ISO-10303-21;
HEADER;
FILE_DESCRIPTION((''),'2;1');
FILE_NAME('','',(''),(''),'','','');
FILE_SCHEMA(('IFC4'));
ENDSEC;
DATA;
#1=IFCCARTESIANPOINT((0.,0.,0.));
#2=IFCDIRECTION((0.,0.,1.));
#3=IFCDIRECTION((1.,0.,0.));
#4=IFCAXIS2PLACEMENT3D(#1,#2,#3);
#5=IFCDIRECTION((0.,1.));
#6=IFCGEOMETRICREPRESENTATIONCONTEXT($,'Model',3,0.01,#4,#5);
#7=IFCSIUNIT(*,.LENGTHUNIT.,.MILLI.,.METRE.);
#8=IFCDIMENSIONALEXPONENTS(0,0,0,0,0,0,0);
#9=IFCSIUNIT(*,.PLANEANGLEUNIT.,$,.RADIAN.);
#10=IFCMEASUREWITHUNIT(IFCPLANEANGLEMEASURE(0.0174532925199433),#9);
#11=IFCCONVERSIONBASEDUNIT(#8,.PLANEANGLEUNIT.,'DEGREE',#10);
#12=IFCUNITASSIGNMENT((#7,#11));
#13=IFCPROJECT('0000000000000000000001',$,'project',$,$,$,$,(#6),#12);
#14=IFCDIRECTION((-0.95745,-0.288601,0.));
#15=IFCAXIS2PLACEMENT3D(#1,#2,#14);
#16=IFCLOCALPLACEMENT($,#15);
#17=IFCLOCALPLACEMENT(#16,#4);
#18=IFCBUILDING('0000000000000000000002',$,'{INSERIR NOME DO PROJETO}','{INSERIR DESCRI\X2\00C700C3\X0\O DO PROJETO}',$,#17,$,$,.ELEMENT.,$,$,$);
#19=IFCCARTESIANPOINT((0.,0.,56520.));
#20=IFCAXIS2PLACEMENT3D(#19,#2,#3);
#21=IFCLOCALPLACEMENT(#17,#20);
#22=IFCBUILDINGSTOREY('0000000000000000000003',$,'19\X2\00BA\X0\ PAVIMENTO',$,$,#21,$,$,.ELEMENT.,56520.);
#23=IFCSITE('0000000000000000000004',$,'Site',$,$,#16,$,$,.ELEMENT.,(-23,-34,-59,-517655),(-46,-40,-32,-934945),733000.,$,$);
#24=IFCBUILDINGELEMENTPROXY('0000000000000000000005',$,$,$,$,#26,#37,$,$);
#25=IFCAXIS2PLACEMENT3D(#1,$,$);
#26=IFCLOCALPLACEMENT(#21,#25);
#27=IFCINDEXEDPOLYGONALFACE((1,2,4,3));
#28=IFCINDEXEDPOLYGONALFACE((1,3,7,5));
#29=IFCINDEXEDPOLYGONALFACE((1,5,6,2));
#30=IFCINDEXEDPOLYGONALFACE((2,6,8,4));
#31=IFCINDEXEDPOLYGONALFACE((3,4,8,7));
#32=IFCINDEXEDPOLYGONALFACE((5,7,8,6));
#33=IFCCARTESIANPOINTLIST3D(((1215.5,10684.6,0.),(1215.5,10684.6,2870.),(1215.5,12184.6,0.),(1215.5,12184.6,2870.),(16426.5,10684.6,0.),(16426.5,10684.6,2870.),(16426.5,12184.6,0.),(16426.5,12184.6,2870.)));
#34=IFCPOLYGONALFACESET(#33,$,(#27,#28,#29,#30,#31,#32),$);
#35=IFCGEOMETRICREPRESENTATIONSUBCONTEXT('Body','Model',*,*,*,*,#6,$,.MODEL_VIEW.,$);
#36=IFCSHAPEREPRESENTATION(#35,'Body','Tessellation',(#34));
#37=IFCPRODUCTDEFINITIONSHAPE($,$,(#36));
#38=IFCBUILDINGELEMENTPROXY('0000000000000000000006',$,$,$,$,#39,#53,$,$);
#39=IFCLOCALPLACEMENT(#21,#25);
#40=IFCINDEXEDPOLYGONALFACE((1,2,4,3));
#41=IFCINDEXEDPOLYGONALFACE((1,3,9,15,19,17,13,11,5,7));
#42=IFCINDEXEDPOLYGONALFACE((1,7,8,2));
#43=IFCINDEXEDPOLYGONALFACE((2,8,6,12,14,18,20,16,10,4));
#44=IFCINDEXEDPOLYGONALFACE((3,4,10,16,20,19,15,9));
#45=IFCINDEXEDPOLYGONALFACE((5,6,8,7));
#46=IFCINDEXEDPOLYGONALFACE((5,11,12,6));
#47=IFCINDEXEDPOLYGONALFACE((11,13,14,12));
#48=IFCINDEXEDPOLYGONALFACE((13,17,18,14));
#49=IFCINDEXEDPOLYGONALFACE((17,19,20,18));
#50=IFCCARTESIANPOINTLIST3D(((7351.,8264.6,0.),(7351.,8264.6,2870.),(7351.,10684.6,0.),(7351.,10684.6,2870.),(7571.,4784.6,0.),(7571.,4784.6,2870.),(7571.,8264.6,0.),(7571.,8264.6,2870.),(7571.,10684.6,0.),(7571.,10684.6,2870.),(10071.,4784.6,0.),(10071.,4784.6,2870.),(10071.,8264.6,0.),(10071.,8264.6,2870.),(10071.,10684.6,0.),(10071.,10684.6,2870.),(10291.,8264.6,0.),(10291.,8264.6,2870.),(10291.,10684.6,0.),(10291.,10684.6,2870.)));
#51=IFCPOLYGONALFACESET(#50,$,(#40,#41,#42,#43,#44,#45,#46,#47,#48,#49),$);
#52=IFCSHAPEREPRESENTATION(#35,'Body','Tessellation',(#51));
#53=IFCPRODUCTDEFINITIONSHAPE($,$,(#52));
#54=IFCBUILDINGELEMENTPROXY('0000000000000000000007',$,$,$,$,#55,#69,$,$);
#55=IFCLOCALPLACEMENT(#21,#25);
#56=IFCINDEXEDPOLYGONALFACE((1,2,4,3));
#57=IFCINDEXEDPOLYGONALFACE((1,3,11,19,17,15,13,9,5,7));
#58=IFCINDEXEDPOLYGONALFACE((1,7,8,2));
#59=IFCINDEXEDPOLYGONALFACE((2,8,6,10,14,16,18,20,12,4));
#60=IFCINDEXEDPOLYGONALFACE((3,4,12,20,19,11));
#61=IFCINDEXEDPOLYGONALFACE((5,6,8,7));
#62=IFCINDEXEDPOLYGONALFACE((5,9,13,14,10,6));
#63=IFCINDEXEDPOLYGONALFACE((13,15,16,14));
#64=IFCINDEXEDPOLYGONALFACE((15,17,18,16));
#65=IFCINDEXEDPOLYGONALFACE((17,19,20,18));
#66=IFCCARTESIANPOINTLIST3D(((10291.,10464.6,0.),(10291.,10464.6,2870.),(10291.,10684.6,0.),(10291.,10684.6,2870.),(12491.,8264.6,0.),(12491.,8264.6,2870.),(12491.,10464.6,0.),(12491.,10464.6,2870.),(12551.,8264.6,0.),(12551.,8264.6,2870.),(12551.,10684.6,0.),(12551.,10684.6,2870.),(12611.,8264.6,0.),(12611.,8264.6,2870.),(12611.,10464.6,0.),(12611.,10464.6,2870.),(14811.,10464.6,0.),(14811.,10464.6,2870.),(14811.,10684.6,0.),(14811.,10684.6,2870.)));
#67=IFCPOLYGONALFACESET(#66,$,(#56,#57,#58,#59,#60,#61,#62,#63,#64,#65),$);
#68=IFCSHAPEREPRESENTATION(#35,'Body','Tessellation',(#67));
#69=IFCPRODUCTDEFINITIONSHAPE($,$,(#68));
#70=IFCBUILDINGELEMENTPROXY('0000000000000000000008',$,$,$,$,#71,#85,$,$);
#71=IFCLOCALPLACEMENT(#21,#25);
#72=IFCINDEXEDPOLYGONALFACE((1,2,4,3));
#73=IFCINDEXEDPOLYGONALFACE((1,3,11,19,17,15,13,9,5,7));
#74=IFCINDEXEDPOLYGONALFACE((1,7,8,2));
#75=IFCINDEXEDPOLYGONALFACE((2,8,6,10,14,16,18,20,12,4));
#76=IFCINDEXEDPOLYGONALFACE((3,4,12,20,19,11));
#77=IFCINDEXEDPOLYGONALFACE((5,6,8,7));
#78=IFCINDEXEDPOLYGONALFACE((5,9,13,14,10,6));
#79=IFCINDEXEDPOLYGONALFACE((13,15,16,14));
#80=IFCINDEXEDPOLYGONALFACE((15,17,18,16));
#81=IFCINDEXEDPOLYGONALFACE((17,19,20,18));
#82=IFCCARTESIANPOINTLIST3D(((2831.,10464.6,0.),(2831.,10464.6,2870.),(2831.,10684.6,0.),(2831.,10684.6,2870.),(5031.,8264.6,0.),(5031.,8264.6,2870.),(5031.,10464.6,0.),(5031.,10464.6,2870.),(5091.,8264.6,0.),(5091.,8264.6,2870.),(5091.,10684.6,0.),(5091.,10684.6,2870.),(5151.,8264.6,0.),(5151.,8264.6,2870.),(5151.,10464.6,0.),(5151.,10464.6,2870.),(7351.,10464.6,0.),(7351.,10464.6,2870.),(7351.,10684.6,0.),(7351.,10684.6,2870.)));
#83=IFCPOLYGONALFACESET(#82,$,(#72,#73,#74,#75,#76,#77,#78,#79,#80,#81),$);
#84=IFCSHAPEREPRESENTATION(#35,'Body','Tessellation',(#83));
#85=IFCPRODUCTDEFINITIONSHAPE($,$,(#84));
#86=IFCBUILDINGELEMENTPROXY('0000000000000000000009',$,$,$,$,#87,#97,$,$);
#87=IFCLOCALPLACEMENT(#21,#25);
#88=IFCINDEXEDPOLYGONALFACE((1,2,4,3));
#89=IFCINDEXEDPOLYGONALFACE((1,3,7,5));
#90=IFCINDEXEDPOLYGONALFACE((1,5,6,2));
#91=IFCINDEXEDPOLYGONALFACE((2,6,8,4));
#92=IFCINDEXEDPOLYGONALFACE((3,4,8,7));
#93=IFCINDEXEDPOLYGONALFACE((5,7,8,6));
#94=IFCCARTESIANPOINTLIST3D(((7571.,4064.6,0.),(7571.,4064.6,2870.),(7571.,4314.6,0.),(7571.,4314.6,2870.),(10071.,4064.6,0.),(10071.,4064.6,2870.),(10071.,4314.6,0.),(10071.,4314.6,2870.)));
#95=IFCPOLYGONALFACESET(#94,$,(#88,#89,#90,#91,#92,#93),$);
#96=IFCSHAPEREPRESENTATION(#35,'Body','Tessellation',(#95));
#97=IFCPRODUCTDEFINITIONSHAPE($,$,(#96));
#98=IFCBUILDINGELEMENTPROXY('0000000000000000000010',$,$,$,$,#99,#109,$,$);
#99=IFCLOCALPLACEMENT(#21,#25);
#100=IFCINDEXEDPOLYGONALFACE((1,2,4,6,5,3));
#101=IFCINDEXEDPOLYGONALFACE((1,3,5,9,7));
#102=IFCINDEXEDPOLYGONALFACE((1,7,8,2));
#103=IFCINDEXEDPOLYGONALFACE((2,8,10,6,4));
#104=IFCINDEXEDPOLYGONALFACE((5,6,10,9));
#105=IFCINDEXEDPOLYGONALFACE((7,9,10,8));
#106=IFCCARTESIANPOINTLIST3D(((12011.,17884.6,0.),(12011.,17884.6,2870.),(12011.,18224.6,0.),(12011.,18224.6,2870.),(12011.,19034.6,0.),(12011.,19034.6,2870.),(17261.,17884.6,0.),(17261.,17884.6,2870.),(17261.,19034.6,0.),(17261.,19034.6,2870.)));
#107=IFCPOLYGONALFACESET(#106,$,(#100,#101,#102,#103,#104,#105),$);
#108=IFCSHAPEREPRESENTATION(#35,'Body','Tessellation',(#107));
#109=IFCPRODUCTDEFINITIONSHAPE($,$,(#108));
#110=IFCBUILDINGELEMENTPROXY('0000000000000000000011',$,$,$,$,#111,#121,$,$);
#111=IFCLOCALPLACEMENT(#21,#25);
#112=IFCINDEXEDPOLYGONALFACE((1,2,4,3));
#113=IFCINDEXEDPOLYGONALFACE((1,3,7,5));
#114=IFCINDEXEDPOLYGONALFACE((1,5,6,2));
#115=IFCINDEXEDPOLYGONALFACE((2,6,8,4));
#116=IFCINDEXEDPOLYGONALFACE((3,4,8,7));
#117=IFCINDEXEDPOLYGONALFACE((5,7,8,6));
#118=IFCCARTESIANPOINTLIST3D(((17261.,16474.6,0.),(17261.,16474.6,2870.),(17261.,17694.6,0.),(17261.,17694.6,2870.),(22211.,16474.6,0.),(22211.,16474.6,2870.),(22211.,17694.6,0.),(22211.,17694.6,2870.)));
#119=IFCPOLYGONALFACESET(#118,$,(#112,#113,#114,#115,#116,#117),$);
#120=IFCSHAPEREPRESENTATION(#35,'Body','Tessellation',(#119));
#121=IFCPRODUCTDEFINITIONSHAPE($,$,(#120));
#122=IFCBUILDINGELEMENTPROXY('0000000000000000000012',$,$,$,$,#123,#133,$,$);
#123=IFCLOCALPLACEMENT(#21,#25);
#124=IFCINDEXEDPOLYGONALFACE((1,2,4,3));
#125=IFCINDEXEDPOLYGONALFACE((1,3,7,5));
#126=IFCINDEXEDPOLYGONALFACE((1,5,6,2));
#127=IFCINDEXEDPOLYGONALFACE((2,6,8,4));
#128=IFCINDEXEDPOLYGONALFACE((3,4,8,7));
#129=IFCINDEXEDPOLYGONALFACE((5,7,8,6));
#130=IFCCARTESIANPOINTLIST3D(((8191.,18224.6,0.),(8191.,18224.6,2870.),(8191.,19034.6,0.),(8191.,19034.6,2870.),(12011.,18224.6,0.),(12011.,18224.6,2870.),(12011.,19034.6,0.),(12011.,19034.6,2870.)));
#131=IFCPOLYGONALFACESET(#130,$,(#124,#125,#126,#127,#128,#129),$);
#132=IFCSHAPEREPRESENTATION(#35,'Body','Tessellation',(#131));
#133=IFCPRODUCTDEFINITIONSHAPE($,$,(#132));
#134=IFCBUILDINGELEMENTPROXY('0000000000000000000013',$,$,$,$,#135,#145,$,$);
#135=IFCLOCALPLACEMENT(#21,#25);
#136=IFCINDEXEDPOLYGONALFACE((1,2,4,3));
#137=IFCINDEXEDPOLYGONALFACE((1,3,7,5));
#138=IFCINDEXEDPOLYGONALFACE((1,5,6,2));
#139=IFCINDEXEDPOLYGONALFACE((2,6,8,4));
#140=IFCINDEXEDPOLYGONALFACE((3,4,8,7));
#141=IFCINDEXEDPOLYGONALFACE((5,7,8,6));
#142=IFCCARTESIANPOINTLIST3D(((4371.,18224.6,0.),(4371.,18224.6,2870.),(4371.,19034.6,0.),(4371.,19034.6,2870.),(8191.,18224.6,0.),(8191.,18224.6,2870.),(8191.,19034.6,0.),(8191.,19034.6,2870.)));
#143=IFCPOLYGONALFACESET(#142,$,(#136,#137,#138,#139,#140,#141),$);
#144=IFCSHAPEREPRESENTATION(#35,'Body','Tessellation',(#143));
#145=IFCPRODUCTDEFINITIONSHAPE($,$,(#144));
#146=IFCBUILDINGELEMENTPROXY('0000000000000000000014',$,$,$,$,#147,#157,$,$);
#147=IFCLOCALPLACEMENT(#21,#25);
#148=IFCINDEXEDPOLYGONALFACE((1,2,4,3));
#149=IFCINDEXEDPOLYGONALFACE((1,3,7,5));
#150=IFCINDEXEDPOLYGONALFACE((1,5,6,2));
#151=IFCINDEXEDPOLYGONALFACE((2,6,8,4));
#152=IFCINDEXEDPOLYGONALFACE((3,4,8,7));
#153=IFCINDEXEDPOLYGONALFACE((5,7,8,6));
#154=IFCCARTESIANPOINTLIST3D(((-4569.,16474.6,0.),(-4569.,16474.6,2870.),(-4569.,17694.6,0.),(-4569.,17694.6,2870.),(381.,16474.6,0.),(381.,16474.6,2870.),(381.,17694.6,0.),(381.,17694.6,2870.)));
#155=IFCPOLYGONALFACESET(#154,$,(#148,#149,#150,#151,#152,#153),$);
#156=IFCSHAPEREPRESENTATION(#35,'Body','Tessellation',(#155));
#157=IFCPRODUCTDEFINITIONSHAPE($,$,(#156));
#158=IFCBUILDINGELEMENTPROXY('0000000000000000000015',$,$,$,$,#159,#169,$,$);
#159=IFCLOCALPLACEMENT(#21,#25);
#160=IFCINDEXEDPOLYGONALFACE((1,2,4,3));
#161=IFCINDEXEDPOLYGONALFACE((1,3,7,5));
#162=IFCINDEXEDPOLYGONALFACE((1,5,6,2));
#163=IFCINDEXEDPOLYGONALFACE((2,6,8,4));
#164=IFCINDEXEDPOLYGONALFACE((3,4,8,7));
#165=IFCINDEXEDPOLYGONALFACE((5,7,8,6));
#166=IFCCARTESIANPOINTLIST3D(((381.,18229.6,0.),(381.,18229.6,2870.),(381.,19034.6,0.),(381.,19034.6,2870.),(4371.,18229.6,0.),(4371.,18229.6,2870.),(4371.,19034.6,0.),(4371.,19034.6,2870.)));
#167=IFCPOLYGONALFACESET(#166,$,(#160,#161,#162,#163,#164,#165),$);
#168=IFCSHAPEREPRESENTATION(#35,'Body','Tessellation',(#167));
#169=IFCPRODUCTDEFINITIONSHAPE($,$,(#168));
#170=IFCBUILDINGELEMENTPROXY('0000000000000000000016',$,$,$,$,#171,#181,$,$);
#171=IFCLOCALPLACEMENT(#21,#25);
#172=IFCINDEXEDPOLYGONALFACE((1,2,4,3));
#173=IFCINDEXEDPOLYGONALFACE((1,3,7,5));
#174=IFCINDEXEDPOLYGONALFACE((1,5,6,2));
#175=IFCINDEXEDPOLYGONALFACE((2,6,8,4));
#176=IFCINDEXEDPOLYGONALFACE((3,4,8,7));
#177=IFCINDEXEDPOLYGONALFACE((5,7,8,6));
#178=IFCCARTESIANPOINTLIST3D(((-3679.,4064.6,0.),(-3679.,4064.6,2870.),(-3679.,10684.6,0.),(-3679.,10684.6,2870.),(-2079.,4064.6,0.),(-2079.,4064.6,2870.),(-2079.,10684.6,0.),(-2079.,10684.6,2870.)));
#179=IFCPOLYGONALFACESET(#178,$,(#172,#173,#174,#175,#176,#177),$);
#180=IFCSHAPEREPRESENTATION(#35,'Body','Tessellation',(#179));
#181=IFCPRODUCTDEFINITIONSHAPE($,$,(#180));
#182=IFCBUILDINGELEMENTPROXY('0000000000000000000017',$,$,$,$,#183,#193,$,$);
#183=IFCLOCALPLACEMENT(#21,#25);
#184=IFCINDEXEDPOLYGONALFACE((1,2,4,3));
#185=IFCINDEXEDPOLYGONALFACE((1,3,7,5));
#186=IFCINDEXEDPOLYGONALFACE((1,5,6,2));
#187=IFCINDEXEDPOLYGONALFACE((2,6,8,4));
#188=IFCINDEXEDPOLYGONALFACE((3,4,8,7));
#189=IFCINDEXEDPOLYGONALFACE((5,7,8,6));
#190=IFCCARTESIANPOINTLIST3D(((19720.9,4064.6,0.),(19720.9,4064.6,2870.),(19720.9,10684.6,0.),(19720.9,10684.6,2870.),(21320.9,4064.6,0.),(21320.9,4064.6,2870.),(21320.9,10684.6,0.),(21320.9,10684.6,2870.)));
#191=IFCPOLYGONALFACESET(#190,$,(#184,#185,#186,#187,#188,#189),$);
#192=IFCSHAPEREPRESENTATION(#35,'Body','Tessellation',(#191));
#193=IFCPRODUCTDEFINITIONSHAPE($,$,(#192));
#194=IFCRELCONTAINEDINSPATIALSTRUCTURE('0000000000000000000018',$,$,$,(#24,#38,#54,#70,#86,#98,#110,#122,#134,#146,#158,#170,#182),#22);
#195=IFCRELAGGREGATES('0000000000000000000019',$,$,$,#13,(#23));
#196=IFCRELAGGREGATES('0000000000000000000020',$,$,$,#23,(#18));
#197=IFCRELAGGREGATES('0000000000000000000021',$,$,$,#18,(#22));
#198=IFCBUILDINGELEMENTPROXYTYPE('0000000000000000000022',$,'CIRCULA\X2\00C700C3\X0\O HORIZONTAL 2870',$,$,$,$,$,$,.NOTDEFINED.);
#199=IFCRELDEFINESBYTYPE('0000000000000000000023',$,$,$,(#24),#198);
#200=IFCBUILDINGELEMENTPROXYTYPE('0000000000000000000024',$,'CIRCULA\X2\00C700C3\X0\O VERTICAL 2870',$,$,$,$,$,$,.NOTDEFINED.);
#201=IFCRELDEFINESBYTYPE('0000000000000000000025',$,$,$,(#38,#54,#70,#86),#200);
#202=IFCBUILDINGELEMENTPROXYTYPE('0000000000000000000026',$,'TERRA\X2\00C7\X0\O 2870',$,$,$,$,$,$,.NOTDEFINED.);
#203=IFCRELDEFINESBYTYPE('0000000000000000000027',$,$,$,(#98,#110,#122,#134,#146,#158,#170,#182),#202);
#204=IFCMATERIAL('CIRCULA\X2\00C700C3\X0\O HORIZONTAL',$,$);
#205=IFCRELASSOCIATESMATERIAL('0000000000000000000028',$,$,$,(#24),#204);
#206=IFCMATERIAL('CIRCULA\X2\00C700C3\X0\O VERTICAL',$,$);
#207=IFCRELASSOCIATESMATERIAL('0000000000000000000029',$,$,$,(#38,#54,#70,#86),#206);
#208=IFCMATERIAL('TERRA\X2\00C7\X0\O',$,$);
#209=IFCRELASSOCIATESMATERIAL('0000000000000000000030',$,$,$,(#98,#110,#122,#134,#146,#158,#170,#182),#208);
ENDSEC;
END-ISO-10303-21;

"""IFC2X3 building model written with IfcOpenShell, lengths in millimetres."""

from ifc_helpers import new_model, entity, si_unit, converted_unit, direction, frame, origin_with_axes, place, context, subcontext, project, spatial, polyline, outline, extrude, material, type_object, element, save


model = new_model("IFC2X3")

# Units and contexts
model_context = context("Model", 3, precision=0.01, world=origin_with_axes(), true_north=direction((0.0, 1.0)))
body_context = subcontext(model_context, "Body", "Model", "MODEL_VIEW")
ifc_project = project(units=[si_unit("LENGTHUNIT", "METRE", prefix="MILLI"), converted_unit("PLANEANGLEUNIT", "DEGREE", entity("IfcPlaneAngleMeasure", 0.0174532925199433), si_unit("PLANEANGLEUNIT", "RADIAN"), dimensions=[0, 0, 0, 0, 0, 0, 0])], contexts=[model_context])

# Site, building, storey
site_placement = place(None, frame((0.0, 0.0, 0.0), z_axis=(0.0, 0.0, 1.0), x_axis=(-0.95745, -0.288601, 0.0)))
site = spatial("IfcSite", under=ifc_project, at=site_placement, Name="Site", CompositionType="ELEMENT", RefLatitude=(-23, -34, -59, -517655), RefLongitude=(-46, -40, -32, -934945), RefElevation=733000.0)
building_placement = place(site_placement, origin_with_axes())
building = spatial("IfcBuilding", under=site, at=building_placement, Name="{INSERIR NOME DO PROJETO}", Description="{INSERIR DESCRIÇÃO DO PROJETO}", CompositionType="ELEMENT")
storey_placement = place(building_placement, frame((0.0, 0.0, 56520.0), z_axis=(0.0, 0.0, 1.0), x_axis=(1.0, 0.0, 0.0)))
storey = spatial("IfcBuildingStorey", under=building, at=storey_placement, Name="19º PAVIMENTO", CompositionType="ELEMENT", Elevation=56520.0)

# Building element proxies
ifc_material_1 = material(Name="CIRCULAÇÃO HORIZONTAL")
building_element_proxy_type_1 = type_object("IfcBuildingElementProxyType", Name="CIRCULAÇÃO HORIZONTAL 2870", PredefinedType="NOTDEFINED")
proxy_1_placement = place(storey_placement, frame((1215.5, 10684.6, 0.0), z_axis=(0.0, 0.0, 1.0), x_axis=(1.0, 0.0, 0.0)))
element("IfcBuildingElementProxy", 1, at=proxy_1_placement, inside=storey, type_object=building_element_proxy_type_1, material=ifc_material_1, context=body_context, shape_type="SweptSolid", body=[
    extrude(outline(polyline([(0.0, 0.0), (15211.0, 0.0), (15211.0, 1500.0), (0.0, 1500.0), (0.0, 0.0)])), origin_with_axes(), (0.0, 0.0, 1.0), 2870.0),
])
ifc_material_2 = material(Name="CIRCULAÇÃO VERTICAL")
building_element_proxy_type_2 = type_object("IfcBuildingElementProxyType", Name="CIRCULAÇÃO VERTICAL 2870", PredefinedType="NOTDEFINED")
proxy_2_placement = place(storey_placement, frame((7351.0, 10684.6, 0.0), z_axis=(0.0, 0.0, 1.0), x_axis=(1.0, 0.0, 0.0)))
element("IfcBuildingElementProxy", 2, at=proxy_2_placement, inside=storey, type_object=building_element_proxy_type_2, material=ifc_material_2, context=body_context, shape_type="SweptSolid", body=[
    extrude(outline(polyline([(0.0, 0.0), (0.0, -2420.0), (220.0, -2420.0), (220.0, -5900.0), (2720.0, -5900.0), (2720.0, -2420.0), (2940.0, -2420.0), (2940.0, 0.0), (2720.0, 0.0), (220.0, 0.0), (0.0, 0.0)])), origin_with_axes(), (0.0, 0.0, 1.0), 2870.0),
])
proxy_3_placement = place(storey_placement, frame((10291.0, 10684.6, 0.0), z_axis=(0.0, 0.0, 1.0), x_axis=(1.0, 0.0, 0.0)))
element("IfcBuildingElementProxy", 3, at=proxy_3_placement, inside=storey, type_object=building_element_proxy_type_2, material=ifc_material_2, context=body_context, shape_type="SweptSolid", body=[
    extrude(outline(polyline([(0.0, 0.0), (0.0, -220.0), (2200.0, -220.0), (2200.0, -2420.0), (2260.0, -2420.0), (2320.0, -2420.0), (2320.0, -220.0), (4520.0, -220.0), (4520.0, 0.0), (2260.0, 0.0), (0.0, 0.0)])), origin_with_axes(), (0.0, 0.0, 1.0), 2870.0),
])
proxy_4_placement = place(storey_placement, frame((5091.0, 10684.6, 0.0), z_axis=(0.0, 0.0, 1.0), x_axis=(1.0, 0.0, 0.0)))
element("IfcBuildingElementProxy", 4, at=proxy_4_placement, inside=storey, type_object=building_element_proxy_type_2, material=ifc_material_2, context=body_context, shape_type="SweptSolid", body=[
    extrude(outline(polyline([(0.0, 0.0), (-2260.0, 0.0), (-2260.0, -220.0), (-60.0, -220.0), (-60.0, -2420.0), (0.0, -2420.0), (60.0, -2420.0), (60.0, -220.0), (2260.0, -220.0), (2260.0, 0.0), (0.0, 0.0)])), origin_with_axes(), (0.0, 0.0, 1.0), 2870.0),
])
proxy_5_placement = place(storey_placement, frame((7571.0, 4064.6, 0.0), z_axis=(0.0, 0.0, 1.0), x_axis=(1.0, 0.0, 0.0)))
element("IfcBuildingElementProxy", 5, at=proxy_5_placement, inside=storey, type_object=building_element_proxy_type_2, material=ifc_material_2, context=body_context, shape_type="SweptSolid", body=[
    extrude(outline(polyline([(0.0, 0.0), (2500.0, 0.0), (2500.0, 250.0), (0.0, 250.0), (0.0, 0.0)])), origin_with_axes(), (0.0, 0.0, 1.0), 2870.0),
])
ifc_material_3 = material(Name="TERRAÇO")
building_element_proxy_type_3 = type_object("IfcBuildingElementProxyType", Name="TERRAÇO 2870", PredefinedType="NOTDEFINED")
proxy_6_placement = place(storey_placement, frame((12011.0, 19034.6, 0.0), z_axis=(0.0, 0.0, 1.0), x_axis=(1.0, 0.0, 0.0)))
element("IfcBuildingElementProxy", 6, at=proxy_6_placement, inside=storey, type_object=building_element_proxy_type_3, material=ifc_material_3, context=body_context, shape_type="SweptSolid", body=[
    extrude(outline(polyline([(0.0, 0.0), (0.0, -810.0), (0.0, -1150.0), (5250.0, -1150.0), (5250.0, 0.0), (0.0, 0.0)])), origin_with_axes(), (0.0, 0.0, 1.0), 2870.0),
])
proxy_7_placement = place(storey_placement, frame((17261.0, 16474.6, 0.0), z_axis=(0.0, 0.0, 1.0), x_axis=(1.0, 0.0, 0.0)))
element("IfcBuildingElementProxy", 7, at=proxy_7_placement, inside=storey, type_object=building_element_proxy_type_3, material=ifc_material_3, context=body_context, shape_type="SweptSolid", body=[
    extrude(outline(polyline([(0.0, 0.0), (4950.0, 0.0), (4950.0, 1220.0), (0.0, 1220.0), (0.0, 0.0)])), origin_with_axes(), (0.0, 0.0, 1.0), 2870.0),
])
for number, where, z_axis, x_axis in (
    (8, (8191.0, 18224.6, 0.0), (0.0, 0.0, 1.0), (1.0, 0.0, 0.0)),
    (9, (4371.0, 18224.6, 0.0), (0.0, 0.0, 1.0), (1.0, 0.0, 0.0)),
):
    element("IfcBuildingElementProxy", number, at=place(storey_placement, frame(where, z_axis=z_axis, x_axis=x_axis)), inside=storey, type_object=building_element_proxy_type_3, material=ifc_material_3, context=body_context, shape_type="SweptSolid", body=[
        extrude(outline(polyline([(0.0, 0.0), (3820.0, 0.0), (3820.0, 810.0), (0.0, 810.0), (0.0, 0.0)])), origin_with_axes(), (0.0, 0.0, 1.0), 2870.0),
    ])
proxy_8_placement = place(storey_placement, frame((381.0, 17694.6, 0.0), z_axis=(0.0, 0.0, 1.0), x_axis=(1.0, 0.0, 0.0)))
element("IfcBuildingElementProxy", 10, at=proxy_8_placement, inside=storey, type_object=building_element_proxy_type_3, material=ifc_material_3, context=body_context, shape_type="SweptSolid", body=[
    extrude(outline(polyline([(0.0, 0.0), (-4950.0, 0.0), (-4950.0, -1220.0), (0.0, -1220.0), (0.0, 0.0)])), origin_with_axes(), (0.0, 0.0, 1.0), 2870.0),
])
proxy_9_placement = place(storey_placement, frame((381.0, 19034.6, 0.0), z_axis=(0.0, 0.0, 1.0), x_axis=(1.0, 0.0, 0.0)))
element("IfcBuildingElementProxy", 11, at=proxy_9_placement, inside=storey, type_object=building_element_proxy_type_3, material=ifc_material_3, context=body_context, shape_type="SweptSolid", body=[
    extrude(outline(polyline([(0.0, 0.0), (0.0, -805.0), (3990.0, -805.0), (3990.0, 0.0), (0.0, 0.0)])), origin_with_axes(), (0.0, 0.0, 1.0), 2870.0),
])
proxy_10_placement = place(storey_placement, frame((-3679.0, 4064.6, 0.0), z_axis=(0.0, 0.0, 1.0), x_axis=(1.0, 0.0, 0.0)))
element("IfcBuildingElementProxy", 12, at=proxy_10_placement, inside=storey, type_object=building_element_proxy_type_3, material=ifc_material_3, context=body_context, shape_type="SweptSolid", body=[
    extrude(outline(polyline([(0.0, 0.0), (1600.0, 0.0), (1600.0, 6620.0), (0.0, 6620.0), (0.0, 0.0)])), origin_with_axes(), (0.0, 0.0, 1.0), 2870.0),
])
proxy_11_placement = place(storey_placement, frame((21320.9, 4064.6, 0.0), z_axis=(0.0, 0.0, 1.0), x_axis=(1.0, 0.0, 0.0)))
element("IfcBuildingElementProxy", 13, at=proxy_11_placement, inside=storey, type_object=building_element_proxy_type_3, material=ifc_material_3, context=body_context, shape_type="SweptSolid", body=[
    extrude(outline(polyline([(0.0, 0.0), (0.0, 6620.0), (-1600.0, 6620.0), (-1600.0, 0.0), (0.0, 0.0)])), origin_with_axes(), (0.0, 0.0, 1.0), 2870.0),
])

save(model, "model.ifc")
